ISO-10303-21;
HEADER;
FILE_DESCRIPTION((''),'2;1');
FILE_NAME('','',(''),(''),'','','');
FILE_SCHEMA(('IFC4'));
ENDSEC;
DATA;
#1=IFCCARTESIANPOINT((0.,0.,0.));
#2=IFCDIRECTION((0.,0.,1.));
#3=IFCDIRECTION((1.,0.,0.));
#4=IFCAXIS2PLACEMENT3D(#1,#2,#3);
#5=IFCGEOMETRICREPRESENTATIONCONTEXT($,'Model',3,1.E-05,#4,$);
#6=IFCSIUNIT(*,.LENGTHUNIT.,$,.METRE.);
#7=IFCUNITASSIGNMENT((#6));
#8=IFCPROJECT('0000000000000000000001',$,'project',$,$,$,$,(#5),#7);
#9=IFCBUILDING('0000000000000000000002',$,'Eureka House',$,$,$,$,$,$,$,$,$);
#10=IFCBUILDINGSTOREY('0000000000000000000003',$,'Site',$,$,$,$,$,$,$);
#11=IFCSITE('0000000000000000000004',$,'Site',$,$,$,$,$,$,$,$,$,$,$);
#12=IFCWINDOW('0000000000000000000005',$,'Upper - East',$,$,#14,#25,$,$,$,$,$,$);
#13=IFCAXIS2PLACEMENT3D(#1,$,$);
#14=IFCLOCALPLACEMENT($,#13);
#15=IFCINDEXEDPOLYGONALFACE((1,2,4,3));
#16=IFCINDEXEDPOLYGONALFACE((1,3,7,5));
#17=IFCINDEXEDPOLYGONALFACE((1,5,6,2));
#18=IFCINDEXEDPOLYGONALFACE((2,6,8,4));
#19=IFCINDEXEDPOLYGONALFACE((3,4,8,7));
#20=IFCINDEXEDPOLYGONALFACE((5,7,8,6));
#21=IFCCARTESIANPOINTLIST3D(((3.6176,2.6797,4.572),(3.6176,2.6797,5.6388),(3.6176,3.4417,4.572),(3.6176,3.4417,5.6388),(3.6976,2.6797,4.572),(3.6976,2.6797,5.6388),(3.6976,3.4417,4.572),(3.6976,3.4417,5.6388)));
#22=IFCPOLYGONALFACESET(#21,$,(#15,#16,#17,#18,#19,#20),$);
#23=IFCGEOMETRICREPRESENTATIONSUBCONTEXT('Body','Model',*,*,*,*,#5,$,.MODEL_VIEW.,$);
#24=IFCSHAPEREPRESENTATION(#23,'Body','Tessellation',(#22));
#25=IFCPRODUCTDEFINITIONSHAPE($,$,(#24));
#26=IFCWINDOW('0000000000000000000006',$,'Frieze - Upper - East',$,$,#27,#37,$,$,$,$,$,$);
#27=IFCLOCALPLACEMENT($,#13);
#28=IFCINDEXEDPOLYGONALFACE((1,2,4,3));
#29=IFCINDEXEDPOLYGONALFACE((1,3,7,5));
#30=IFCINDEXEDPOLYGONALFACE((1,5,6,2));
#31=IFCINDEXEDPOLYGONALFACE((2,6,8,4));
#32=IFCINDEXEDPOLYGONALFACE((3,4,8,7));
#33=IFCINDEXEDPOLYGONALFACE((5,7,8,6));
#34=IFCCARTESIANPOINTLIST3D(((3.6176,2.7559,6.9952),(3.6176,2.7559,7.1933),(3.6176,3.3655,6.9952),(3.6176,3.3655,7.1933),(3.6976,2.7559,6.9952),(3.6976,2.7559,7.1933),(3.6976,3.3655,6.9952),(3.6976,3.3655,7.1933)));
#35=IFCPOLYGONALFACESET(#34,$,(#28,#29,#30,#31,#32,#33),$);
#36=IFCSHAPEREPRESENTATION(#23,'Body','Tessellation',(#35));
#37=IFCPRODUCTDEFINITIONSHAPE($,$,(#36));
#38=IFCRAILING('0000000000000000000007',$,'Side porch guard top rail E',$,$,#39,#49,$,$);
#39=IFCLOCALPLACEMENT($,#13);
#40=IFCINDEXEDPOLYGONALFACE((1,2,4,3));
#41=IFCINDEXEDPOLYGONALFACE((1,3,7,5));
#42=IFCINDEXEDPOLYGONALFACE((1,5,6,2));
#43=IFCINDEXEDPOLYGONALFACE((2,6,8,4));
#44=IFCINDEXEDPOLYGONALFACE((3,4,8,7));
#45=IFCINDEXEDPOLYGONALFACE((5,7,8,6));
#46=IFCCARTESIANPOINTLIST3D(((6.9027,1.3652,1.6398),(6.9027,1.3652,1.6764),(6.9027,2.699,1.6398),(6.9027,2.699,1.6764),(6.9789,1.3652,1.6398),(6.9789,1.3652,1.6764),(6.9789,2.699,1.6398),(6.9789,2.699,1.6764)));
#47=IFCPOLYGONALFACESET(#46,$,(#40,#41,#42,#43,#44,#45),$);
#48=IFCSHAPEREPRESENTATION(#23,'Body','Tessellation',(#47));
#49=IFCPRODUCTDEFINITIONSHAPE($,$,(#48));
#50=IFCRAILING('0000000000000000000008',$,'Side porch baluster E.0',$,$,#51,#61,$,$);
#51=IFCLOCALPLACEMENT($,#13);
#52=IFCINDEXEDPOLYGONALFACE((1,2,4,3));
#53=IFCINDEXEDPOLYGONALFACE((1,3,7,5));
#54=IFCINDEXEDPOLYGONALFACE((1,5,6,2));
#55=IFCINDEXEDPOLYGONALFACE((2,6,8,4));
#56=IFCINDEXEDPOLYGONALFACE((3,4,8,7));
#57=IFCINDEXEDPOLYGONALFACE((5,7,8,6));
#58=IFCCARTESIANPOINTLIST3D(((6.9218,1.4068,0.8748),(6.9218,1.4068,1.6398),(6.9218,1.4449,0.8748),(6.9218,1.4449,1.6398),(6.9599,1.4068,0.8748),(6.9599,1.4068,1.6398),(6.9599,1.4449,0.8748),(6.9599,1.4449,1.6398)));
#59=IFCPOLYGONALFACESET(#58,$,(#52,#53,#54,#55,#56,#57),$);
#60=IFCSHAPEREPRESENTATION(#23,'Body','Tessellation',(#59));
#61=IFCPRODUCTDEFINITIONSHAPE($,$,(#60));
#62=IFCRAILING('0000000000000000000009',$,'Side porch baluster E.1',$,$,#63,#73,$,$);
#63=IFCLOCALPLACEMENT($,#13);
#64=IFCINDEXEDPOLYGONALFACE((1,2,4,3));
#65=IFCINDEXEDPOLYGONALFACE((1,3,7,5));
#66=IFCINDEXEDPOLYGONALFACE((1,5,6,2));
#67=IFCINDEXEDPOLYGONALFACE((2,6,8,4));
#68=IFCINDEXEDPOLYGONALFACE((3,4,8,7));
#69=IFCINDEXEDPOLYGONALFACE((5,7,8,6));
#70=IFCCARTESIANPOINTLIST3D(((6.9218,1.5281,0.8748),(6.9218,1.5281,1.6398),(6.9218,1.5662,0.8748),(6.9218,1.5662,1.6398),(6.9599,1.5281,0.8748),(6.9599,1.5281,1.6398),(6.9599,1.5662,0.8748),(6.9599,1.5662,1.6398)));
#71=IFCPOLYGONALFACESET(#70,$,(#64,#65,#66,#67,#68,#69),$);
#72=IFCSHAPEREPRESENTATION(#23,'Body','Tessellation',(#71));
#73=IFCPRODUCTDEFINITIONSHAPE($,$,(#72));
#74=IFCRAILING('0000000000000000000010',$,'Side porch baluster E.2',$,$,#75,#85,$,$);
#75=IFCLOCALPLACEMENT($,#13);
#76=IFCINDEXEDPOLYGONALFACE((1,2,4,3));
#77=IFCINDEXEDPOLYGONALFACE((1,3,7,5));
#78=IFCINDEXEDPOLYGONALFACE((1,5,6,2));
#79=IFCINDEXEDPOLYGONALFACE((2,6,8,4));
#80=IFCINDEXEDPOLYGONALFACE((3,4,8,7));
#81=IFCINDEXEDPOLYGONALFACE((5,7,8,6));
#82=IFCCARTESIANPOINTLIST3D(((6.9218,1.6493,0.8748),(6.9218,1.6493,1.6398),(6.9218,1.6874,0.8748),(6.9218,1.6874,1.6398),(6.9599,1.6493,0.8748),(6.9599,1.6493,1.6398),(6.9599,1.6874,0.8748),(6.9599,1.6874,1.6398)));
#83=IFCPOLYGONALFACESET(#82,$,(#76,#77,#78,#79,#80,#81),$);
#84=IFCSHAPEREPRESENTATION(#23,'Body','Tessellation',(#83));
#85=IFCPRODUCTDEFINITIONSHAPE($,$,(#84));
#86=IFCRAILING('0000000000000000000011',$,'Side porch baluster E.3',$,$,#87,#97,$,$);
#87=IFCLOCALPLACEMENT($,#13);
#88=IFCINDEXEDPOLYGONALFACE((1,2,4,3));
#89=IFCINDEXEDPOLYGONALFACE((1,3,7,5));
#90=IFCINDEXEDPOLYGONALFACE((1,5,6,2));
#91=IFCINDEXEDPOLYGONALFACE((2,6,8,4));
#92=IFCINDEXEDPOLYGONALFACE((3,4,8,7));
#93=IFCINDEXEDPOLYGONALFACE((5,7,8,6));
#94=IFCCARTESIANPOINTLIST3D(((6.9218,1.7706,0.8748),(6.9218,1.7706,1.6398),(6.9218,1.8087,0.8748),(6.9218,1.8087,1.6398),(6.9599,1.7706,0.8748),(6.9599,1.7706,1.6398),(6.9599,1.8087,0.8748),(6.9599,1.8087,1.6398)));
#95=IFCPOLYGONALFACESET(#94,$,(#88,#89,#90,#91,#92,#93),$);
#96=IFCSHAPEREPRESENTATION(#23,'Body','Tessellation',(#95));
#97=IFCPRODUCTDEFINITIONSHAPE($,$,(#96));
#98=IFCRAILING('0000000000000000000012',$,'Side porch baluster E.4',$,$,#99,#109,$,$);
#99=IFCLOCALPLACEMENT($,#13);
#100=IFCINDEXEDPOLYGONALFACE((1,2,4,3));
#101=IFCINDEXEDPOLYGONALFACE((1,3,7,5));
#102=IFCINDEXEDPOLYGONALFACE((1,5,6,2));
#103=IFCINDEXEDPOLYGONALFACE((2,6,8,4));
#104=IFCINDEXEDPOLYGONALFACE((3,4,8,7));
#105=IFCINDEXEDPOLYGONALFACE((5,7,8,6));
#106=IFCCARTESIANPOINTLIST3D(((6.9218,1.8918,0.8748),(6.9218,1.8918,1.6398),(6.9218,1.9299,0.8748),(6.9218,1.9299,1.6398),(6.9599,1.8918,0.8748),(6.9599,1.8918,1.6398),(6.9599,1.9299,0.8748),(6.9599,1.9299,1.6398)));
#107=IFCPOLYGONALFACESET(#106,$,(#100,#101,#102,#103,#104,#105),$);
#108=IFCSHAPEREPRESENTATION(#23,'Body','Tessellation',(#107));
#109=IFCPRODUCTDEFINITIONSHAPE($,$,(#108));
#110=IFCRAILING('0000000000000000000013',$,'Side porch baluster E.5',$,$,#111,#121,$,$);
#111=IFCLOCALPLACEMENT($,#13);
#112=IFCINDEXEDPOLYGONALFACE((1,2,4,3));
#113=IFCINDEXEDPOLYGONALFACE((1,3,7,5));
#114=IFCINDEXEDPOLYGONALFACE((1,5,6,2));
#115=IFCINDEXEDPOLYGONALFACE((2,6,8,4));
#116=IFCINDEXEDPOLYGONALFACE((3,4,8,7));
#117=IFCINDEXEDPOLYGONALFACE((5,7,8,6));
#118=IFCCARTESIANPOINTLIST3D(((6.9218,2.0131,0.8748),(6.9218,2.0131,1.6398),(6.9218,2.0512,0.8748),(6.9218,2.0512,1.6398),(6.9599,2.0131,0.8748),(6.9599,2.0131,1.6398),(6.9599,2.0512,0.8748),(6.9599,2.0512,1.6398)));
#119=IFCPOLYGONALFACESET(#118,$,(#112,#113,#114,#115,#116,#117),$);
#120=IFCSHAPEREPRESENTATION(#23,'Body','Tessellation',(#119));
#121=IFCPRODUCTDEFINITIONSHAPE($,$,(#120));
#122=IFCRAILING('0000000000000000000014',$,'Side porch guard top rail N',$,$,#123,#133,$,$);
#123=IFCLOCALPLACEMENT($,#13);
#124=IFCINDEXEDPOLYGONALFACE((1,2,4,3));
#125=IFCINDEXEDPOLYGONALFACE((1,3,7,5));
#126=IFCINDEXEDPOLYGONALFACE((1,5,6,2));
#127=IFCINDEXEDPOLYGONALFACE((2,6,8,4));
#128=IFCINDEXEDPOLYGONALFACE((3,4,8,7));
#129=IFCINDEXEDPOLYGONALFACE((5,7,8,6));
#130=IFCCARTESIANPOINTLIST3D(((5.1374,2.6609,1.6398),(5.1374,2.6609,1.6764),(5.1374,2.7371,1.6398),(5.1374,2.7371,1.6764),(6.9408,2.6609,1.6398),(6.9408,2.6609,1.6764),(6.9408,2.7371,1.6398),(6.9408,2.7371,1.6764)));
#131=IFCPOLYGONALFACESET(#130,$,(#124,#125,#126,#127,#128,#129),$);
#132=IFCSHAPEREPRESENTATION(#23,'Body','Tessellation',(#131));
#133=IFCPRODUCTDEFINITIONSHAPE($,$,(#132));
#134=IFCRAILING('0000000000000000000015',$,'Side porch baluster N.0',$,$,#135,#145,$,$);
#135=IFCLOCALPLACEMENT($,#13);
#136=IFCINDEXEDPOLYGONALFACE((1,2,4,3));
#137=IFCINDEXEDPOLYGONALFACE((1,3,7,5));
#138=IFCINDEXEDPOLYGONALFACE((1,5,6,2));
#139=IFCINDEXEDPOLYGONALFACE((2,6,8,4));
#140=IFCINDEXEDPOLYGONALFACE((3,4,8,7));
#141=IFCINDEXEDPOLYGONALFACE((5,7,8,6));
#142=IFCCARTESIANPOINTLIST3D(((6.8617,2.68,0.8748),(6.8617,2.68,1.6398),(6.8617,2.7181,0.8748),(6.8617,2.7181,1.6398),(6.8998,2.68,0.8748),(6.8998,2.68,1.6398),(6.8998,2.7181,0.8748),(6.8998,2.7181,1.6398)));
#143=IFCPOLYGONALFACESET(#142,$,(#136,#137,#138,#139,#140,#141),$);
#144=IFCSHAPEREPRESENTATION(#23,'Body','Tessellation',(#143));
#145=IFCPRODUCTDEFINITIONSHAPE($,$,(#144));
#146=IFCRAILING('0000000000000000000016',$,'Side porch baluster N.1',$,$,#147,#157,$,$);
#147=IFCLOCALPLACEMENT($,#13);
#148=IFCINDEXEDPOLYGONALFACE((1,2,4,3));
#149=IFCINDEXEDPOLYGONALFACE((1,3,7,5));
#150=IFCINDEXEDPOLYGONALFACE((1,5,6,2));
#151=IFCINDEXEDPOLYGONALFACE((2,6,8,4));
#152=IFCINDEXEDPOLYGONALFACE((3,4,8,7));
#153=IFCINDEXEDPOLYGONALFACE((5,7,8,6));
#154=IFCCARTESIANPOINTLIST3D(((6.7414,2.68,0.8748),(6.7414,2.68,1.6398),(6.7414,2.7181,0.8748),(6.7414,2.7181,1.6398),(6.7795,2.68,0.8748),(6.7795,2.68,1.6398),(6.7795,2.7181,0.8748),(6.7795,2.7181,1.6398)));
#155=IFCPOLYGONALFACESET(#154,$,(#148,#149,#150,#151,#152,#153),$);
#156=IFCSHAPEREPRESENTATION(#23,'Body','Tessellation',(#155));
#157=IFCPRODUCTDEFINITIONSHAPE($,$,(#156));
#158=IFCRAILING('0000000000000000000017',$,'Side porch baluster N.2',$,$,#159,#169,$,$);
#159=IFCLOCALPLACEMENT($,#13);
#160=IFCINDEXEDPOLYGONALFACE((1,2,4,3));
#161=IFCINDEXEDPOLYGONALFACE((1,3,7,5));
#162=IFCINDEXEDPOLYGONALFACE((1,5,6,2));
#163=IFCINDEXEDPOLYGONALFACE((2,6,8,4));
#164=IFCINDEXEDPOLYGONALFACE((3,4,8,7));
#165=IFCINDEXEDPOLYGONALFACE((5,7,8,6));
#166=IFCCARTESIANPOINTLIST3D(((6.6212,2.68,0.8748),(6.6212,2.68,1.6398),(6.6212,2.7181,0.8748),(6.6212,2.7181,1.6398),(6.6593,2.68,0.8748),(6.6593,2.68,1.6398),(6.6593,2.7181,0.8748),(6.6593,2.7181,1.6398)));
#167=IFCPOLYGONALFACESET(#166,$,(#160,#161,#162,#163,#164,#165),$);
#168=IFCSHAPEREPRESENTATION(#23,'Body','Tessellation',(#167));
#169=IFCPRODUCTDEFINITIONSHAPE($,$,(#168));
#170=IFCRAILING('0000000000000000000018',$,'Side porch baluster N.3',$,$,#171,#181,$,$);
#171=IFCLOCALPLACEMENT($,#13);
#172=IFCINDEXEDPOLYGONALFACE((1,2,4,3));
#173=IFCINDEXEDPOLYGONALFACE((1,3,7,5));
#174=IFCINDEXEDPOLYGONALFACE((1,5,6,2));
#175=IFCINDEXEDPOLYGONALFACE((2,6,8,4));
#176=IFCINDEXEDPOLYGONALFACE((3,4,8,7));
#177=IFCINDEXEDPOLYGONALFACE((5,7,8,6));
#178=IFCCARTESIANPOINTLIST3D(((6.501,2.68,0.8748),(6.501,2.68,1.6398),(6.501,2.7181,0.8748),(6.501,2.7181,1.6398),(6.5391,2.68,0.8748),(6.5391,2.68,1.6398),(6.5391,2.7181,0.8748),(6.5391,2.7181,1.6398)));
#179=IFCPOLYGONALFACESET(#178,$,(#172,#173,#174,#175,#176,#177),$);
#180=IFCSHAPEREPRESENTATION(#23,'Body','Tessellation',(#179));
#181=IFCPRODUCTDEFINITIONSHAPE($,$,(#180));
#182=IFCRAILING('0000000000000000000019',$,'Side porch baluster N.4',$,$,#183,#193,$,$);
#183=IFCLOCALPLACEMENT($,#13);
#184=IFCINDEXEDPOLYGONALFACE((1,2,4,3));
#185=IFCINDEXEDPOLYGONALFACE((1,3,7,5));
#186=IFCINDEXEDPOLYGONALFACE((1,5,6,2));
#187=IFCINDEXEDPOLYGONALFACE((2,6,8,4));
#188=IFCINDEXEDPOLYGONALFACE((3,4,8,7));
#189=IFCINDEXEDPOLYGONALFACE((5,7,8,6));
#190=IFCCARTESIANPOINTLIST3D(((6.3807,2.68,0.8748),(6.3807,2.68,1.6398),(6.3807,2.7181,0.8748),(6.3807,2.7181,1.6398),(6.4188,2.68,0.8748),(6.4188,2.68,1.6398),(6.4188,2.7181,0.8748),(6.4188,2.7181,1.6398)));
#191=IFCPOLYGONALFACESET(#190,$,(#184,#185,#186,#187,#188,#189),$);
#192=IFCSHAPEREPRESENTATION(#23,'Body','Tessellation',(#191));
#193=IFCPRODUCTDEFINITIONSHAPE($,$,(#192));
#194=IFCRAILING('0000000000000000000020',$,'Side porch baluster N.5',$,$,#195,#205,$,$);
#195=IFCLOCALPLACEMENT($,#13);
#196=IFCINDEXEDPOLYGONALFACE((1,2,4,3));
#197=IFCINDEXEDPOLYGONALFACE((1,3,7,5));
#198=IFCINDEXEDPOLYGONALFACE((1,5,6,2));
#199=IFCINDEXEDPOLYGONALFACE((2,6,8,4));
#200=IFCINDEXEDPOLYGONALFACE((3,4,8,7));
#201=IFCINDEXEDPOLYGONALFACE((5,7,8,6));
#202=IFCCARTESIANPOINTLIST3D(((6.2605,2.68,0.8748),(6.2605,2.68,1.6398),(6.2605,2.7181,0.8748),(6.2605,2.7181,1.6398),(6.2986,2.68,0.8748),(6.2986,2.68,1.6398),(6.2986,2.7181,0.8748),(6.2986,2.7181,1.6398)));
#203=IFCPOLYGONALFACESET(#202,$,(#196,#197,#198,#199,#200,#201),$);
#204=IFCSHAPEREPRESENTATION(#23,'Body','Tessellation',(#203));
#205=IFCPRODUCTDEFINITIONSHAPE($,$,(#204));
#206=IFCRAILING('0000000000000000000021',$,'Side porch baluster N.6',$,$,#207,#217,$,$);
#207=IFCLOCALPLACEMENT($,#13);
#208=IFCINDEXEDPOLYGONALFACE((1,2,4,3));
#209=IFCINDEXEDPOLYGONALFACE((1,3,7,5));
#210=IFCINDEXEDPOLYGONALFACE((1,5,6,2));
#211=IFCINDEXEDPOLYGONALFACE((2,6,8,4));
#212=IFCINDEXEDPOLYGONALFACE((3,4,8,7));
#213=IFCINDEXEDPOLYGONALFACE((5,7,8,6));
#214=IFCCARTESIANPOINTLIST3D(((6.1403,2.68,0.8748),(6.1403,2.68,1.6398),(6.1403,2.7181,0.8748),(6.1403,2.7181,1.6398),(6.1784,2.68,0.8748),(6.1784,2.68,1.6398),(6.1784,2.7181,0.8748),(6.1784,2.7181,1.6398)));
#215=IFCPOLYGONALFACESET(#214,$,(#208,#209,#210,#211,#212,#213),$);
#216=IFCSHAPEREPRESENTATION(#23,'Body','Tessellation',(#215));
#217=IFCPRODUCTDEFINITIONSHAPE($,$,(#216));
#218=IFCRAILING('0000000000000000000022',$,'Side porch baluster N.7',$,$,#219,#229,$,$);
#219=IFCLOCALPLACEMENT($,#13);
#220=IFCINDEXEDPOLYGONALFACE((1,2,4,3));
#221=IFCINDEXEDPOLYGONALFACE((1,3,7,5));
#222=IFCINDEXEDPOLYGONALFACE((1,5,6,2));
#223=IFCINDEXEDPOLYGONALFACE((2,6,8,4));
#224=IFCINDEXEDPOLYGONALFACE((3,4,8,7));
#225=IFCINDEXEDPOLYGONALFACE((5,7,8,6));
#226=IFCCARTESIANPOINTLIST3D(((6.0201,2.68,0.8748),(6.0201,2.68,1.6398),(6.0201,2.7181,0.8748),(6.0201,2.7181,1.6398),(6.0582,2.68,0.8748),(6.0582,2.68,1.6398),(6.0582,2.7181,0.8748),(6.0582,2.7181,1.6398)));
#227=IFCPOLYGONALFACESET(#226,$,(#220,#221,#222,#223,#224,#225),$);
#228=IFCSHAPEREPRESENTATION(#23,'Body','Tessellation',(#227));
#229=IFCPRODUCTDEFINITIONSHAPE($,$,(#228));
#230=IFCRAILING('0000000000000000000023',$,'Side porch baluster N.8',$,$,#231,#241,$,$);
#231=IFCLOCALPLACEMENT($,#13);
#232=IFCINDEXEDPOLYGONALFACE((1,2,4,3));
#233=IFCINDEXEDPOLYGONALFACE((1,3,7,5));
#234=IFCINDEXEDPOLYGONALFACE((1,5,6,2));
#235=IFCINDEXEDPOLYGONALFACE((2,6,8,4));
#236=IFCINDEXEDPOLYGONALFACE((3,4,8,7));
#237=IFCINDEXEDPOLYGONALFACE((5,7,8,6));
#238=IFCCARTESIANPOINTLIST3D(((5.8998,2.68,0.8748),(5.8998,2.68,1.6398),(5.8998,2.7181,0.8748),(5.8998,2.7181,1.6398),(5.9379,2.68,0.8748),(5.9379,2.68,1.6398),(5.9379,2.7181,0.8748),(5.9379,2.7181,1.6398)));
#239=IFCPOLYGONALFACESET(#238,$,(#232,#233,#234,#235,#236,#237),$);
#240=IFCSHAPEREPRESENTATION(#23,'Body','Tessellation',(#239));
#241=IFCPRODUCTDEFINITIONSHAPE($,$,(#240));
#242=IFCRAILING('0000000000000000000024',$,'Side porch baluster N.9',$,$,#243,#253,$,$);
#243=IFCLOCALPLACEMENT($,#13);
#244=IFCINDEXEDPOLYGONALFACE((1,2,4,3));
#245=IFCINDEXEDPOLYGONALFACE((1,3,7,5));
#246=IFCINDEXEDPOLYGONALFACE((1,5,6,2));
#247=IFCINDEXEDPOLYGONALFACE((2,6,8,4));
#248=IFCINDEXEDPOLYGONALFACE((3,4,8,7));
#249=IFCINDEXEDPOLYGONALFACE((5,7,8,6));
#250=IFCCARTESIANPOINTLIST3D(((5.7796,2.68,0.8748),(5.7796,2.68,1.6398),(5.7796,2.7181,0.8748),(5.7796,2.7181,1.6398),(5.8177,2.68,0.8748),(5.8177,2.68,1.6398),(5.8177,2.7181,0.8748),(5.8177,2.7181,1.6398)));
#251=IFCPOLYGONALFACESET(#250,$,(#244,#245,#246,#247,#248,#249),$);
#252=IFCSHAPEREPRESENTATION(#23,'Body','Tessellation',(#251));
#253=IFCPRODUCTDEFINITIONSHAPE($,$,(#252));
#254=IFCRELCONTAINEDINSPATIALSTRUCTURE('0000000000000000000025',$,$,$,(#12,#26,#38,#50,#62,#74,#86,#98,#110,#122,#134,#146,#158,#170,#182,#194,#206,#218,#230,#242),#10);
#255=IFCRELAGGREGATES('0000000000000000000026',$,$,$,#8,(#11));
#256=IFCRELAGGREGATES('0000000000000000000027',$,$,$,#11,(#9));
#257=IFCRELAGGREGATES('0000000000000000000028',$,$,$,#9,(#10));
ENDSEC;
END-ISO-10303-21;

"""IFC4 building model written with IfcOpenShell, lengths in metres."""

from ifc_helpers import new_model, si_unit, frame, origin, origin_with_axes, origin_2d, place, context, subcontext, project, spatial, rectangle, extrude, element, save


model = new_model("IFC4")

# Units and contexts
model_context = context("Model", 3, precision=1e-05, world=origin_with_axes())
body_context = subcontext(model_context, "Body", "Model", "MODEL_VIEW")
ifc_project = project(units=[si_unit("LENGTHUNIT", "METRE")], contexts=[model_context])

# Site, building, storey
site = spatial("IfcSite", under=ifc_project, Name="Site")
building = spatial("IfcBuilding", under=site, Name="Eureka House")
storey = spatial("IfcBuildingStorey", under=building, Name="Site")

# Windows
window_1_placement = place(None, frame((3.6576, 3.0607, 4.572), z_axis=(0.0, 0.0, 1.0), x_axis=(1.0, 0.0, 0.0)))
element("IfcWindow", 1, at=window_1_placement, inside=storey, Name="Upper - East", context=body_context, shape_type="SweptSolid", body=[
    extrude(rectangle(XDim=0.08, YDim=0.762, at=origin_2d()), origin(), (0.0, 0.0, 1.0), 1.0668),
])
window_2_placement = place(None, frame((3.6576, 3.0607, 6.9952), z_axis=(0.0, 0.0, 1.0), x_axis=(1.0, 0.0, 0.0)))
element("IfcWindow", 2, at=window_2_placement, inside=storey, Name="Frieze - Upper - East", context=body_context, shape_type="SweptSolid", body=[
    extrude(rectangle(XDim=0.08, YDim=0.6096, at=origin_2d()), origin(), (0.0, 0.0, 1.0), 0.1981),
])

# Railings
railing_1_placement = place(None, frame((6.9408, 2.0321, 1.6398), z_axis=(0.0, 0.0, 1.0), x_axis=(1.0, 0.0, 0.0)))
element("IfcRailing", 3, at=railing_1_placement, inside=storey, Name="Side porch guard top rail E", context=body_context, shape_type="SweptSolid", body=[
    extrude(rectangle(XDim=0.0762, YDim=1.3338, at=origin_2d()), origin(), (0.0, 0.0, 1.0), 0.0366),
])
for number, where, z_axis, x_axis, name in (
    (4, (6.9408, 1.4259, 0.8748), (0.0, 0.0, 1.0), (1.0, 0.0, 0.0), "Side porch baluster E.0"),
    (5, (6.9408, 1.5471, 0.8748), (0.0, 0.0, 1.0), (1.0, 0.0, 0.0), "Side porch baluster E.1"),
    (6, (6.9408, 1.6684, 0.8748), (0.0, 0.0, 1.0), (1.0, 0.0, 0.0), "Side porch baluster E.2"),
    (7, (6.9408, 1.7896, 0.8748), (0.0, 0.0, 1.0), (1.0, 0.0, 0.0), "Side porch baluster E.3"),
    (8, (6.9408, 1.9109, 0.8748), (0.0, 0.0, 1.0), (1.0, 0.0, 0.0), "Side porch baluster E.4"),
    (9, (6.9408, 2.0321, 0.8748), (0.0, 0.0, 1.0), (1.0, 0.0, 0.0), "Side porch baluster E.5"),
):
    element("IfcRailing", number, at=place(None, frame(where, z_axis=z_axis, x_axis=x_axis)), inside=storey, Name=name, context=body_context, shape_type="SweptSolid", body=[
        extrude(rectangle(XDim=0.0381, YDim=0.0381, at=origin_2d()), origin(), (0.0, 0.0, 1.0), 0.765),
    ])
railing_2_placement = place(None, frame((6.0391, 2.699, 1.6398), z_axis=(0.0, 0.0, 1.0), x_axis=(1.0, 0.0, 0.0)))
element("IfcRailing", 10, at=railing_2_placement, inside=storey, Name="Side porch guard top rail N", context=body_context, shape_type="SweptSolid", body=[
    extrude(rectangle(XDim=1.8034, YDim=0.0762, at=origin_2d()), origin(), (0.0, 0.0, 1.0), 0.0366),
])
for number, where, z_axis, x_axis, name in (
    (11, (6.8807, 2.699, 0.8748), (0.0, 0.0, 1.0), (1.0, 0.0, 0.0), "Side porch baluster N.0"),
    (12, (6.7605, 2.699, 0.8748), (0.0, 0.0, 1.0), (1.0, 0.0, 0.0), "Side porch baluster N.1"),
    (13, (6.6402, 2.699, 0.8748), (0.0, 0.0, 1.0), (1.0, 0.0, 0.0), "Side porch baluster N.2"),
    (14, (6.52, 2.699, 0.8748), (0.0, 0.0, 1.0), (1.0, 0.0, 0.0), "Side porch baluster N.3"),
    (15, (6.3998, 2.699, 0.8748), (0.0, 0.0, 1.0), (1.0, 0.0, 0.0), "Side porch baluster N.4"),
    (16, (6.2796, 2.699, 0.8748), (0.0, 0.0, 1.0), (1.0, 0.0, 0.0), "Side porch baluster N.5"),
    (17, (6.1593, 2.699, 0.8748), (0.0, 0.0, 1.0), (1.0, 0.0, 0.0), "Side porch baluster N.6"),
    (18, (6.0391, 2.699, 0.8748), (0.0, 0.0, 1.0), (1.0, 0.0, 0.0), "Side porch baluster N.7"),
    (19, (5.9189, 2.699, 0.8748), (0.0, 0.0, 1.0), (1.0, 0.0, 0.0), "Side porch baluster N.8"),
    (20, (5.7987, 2.699, 0.8748), (0.0, 0.0, 1.0), (1.0, 0.0, 0.0), "Side porch baluster N.9"),
):
    element("IfcRailing", number, at=place(None, frame(where, z_axis=z_axis, x_axis=x_axis)), inside=storey, Name=name, context=body_context, shape_type="SweptSolid", body=[
        extrude(rectangle(XDim=0.0381, YDim=0.0381, at=origin_2d()), origin(), (0.0, 0.0, 1.0), 0.765),
    ])

save(model, "model.ifc")
